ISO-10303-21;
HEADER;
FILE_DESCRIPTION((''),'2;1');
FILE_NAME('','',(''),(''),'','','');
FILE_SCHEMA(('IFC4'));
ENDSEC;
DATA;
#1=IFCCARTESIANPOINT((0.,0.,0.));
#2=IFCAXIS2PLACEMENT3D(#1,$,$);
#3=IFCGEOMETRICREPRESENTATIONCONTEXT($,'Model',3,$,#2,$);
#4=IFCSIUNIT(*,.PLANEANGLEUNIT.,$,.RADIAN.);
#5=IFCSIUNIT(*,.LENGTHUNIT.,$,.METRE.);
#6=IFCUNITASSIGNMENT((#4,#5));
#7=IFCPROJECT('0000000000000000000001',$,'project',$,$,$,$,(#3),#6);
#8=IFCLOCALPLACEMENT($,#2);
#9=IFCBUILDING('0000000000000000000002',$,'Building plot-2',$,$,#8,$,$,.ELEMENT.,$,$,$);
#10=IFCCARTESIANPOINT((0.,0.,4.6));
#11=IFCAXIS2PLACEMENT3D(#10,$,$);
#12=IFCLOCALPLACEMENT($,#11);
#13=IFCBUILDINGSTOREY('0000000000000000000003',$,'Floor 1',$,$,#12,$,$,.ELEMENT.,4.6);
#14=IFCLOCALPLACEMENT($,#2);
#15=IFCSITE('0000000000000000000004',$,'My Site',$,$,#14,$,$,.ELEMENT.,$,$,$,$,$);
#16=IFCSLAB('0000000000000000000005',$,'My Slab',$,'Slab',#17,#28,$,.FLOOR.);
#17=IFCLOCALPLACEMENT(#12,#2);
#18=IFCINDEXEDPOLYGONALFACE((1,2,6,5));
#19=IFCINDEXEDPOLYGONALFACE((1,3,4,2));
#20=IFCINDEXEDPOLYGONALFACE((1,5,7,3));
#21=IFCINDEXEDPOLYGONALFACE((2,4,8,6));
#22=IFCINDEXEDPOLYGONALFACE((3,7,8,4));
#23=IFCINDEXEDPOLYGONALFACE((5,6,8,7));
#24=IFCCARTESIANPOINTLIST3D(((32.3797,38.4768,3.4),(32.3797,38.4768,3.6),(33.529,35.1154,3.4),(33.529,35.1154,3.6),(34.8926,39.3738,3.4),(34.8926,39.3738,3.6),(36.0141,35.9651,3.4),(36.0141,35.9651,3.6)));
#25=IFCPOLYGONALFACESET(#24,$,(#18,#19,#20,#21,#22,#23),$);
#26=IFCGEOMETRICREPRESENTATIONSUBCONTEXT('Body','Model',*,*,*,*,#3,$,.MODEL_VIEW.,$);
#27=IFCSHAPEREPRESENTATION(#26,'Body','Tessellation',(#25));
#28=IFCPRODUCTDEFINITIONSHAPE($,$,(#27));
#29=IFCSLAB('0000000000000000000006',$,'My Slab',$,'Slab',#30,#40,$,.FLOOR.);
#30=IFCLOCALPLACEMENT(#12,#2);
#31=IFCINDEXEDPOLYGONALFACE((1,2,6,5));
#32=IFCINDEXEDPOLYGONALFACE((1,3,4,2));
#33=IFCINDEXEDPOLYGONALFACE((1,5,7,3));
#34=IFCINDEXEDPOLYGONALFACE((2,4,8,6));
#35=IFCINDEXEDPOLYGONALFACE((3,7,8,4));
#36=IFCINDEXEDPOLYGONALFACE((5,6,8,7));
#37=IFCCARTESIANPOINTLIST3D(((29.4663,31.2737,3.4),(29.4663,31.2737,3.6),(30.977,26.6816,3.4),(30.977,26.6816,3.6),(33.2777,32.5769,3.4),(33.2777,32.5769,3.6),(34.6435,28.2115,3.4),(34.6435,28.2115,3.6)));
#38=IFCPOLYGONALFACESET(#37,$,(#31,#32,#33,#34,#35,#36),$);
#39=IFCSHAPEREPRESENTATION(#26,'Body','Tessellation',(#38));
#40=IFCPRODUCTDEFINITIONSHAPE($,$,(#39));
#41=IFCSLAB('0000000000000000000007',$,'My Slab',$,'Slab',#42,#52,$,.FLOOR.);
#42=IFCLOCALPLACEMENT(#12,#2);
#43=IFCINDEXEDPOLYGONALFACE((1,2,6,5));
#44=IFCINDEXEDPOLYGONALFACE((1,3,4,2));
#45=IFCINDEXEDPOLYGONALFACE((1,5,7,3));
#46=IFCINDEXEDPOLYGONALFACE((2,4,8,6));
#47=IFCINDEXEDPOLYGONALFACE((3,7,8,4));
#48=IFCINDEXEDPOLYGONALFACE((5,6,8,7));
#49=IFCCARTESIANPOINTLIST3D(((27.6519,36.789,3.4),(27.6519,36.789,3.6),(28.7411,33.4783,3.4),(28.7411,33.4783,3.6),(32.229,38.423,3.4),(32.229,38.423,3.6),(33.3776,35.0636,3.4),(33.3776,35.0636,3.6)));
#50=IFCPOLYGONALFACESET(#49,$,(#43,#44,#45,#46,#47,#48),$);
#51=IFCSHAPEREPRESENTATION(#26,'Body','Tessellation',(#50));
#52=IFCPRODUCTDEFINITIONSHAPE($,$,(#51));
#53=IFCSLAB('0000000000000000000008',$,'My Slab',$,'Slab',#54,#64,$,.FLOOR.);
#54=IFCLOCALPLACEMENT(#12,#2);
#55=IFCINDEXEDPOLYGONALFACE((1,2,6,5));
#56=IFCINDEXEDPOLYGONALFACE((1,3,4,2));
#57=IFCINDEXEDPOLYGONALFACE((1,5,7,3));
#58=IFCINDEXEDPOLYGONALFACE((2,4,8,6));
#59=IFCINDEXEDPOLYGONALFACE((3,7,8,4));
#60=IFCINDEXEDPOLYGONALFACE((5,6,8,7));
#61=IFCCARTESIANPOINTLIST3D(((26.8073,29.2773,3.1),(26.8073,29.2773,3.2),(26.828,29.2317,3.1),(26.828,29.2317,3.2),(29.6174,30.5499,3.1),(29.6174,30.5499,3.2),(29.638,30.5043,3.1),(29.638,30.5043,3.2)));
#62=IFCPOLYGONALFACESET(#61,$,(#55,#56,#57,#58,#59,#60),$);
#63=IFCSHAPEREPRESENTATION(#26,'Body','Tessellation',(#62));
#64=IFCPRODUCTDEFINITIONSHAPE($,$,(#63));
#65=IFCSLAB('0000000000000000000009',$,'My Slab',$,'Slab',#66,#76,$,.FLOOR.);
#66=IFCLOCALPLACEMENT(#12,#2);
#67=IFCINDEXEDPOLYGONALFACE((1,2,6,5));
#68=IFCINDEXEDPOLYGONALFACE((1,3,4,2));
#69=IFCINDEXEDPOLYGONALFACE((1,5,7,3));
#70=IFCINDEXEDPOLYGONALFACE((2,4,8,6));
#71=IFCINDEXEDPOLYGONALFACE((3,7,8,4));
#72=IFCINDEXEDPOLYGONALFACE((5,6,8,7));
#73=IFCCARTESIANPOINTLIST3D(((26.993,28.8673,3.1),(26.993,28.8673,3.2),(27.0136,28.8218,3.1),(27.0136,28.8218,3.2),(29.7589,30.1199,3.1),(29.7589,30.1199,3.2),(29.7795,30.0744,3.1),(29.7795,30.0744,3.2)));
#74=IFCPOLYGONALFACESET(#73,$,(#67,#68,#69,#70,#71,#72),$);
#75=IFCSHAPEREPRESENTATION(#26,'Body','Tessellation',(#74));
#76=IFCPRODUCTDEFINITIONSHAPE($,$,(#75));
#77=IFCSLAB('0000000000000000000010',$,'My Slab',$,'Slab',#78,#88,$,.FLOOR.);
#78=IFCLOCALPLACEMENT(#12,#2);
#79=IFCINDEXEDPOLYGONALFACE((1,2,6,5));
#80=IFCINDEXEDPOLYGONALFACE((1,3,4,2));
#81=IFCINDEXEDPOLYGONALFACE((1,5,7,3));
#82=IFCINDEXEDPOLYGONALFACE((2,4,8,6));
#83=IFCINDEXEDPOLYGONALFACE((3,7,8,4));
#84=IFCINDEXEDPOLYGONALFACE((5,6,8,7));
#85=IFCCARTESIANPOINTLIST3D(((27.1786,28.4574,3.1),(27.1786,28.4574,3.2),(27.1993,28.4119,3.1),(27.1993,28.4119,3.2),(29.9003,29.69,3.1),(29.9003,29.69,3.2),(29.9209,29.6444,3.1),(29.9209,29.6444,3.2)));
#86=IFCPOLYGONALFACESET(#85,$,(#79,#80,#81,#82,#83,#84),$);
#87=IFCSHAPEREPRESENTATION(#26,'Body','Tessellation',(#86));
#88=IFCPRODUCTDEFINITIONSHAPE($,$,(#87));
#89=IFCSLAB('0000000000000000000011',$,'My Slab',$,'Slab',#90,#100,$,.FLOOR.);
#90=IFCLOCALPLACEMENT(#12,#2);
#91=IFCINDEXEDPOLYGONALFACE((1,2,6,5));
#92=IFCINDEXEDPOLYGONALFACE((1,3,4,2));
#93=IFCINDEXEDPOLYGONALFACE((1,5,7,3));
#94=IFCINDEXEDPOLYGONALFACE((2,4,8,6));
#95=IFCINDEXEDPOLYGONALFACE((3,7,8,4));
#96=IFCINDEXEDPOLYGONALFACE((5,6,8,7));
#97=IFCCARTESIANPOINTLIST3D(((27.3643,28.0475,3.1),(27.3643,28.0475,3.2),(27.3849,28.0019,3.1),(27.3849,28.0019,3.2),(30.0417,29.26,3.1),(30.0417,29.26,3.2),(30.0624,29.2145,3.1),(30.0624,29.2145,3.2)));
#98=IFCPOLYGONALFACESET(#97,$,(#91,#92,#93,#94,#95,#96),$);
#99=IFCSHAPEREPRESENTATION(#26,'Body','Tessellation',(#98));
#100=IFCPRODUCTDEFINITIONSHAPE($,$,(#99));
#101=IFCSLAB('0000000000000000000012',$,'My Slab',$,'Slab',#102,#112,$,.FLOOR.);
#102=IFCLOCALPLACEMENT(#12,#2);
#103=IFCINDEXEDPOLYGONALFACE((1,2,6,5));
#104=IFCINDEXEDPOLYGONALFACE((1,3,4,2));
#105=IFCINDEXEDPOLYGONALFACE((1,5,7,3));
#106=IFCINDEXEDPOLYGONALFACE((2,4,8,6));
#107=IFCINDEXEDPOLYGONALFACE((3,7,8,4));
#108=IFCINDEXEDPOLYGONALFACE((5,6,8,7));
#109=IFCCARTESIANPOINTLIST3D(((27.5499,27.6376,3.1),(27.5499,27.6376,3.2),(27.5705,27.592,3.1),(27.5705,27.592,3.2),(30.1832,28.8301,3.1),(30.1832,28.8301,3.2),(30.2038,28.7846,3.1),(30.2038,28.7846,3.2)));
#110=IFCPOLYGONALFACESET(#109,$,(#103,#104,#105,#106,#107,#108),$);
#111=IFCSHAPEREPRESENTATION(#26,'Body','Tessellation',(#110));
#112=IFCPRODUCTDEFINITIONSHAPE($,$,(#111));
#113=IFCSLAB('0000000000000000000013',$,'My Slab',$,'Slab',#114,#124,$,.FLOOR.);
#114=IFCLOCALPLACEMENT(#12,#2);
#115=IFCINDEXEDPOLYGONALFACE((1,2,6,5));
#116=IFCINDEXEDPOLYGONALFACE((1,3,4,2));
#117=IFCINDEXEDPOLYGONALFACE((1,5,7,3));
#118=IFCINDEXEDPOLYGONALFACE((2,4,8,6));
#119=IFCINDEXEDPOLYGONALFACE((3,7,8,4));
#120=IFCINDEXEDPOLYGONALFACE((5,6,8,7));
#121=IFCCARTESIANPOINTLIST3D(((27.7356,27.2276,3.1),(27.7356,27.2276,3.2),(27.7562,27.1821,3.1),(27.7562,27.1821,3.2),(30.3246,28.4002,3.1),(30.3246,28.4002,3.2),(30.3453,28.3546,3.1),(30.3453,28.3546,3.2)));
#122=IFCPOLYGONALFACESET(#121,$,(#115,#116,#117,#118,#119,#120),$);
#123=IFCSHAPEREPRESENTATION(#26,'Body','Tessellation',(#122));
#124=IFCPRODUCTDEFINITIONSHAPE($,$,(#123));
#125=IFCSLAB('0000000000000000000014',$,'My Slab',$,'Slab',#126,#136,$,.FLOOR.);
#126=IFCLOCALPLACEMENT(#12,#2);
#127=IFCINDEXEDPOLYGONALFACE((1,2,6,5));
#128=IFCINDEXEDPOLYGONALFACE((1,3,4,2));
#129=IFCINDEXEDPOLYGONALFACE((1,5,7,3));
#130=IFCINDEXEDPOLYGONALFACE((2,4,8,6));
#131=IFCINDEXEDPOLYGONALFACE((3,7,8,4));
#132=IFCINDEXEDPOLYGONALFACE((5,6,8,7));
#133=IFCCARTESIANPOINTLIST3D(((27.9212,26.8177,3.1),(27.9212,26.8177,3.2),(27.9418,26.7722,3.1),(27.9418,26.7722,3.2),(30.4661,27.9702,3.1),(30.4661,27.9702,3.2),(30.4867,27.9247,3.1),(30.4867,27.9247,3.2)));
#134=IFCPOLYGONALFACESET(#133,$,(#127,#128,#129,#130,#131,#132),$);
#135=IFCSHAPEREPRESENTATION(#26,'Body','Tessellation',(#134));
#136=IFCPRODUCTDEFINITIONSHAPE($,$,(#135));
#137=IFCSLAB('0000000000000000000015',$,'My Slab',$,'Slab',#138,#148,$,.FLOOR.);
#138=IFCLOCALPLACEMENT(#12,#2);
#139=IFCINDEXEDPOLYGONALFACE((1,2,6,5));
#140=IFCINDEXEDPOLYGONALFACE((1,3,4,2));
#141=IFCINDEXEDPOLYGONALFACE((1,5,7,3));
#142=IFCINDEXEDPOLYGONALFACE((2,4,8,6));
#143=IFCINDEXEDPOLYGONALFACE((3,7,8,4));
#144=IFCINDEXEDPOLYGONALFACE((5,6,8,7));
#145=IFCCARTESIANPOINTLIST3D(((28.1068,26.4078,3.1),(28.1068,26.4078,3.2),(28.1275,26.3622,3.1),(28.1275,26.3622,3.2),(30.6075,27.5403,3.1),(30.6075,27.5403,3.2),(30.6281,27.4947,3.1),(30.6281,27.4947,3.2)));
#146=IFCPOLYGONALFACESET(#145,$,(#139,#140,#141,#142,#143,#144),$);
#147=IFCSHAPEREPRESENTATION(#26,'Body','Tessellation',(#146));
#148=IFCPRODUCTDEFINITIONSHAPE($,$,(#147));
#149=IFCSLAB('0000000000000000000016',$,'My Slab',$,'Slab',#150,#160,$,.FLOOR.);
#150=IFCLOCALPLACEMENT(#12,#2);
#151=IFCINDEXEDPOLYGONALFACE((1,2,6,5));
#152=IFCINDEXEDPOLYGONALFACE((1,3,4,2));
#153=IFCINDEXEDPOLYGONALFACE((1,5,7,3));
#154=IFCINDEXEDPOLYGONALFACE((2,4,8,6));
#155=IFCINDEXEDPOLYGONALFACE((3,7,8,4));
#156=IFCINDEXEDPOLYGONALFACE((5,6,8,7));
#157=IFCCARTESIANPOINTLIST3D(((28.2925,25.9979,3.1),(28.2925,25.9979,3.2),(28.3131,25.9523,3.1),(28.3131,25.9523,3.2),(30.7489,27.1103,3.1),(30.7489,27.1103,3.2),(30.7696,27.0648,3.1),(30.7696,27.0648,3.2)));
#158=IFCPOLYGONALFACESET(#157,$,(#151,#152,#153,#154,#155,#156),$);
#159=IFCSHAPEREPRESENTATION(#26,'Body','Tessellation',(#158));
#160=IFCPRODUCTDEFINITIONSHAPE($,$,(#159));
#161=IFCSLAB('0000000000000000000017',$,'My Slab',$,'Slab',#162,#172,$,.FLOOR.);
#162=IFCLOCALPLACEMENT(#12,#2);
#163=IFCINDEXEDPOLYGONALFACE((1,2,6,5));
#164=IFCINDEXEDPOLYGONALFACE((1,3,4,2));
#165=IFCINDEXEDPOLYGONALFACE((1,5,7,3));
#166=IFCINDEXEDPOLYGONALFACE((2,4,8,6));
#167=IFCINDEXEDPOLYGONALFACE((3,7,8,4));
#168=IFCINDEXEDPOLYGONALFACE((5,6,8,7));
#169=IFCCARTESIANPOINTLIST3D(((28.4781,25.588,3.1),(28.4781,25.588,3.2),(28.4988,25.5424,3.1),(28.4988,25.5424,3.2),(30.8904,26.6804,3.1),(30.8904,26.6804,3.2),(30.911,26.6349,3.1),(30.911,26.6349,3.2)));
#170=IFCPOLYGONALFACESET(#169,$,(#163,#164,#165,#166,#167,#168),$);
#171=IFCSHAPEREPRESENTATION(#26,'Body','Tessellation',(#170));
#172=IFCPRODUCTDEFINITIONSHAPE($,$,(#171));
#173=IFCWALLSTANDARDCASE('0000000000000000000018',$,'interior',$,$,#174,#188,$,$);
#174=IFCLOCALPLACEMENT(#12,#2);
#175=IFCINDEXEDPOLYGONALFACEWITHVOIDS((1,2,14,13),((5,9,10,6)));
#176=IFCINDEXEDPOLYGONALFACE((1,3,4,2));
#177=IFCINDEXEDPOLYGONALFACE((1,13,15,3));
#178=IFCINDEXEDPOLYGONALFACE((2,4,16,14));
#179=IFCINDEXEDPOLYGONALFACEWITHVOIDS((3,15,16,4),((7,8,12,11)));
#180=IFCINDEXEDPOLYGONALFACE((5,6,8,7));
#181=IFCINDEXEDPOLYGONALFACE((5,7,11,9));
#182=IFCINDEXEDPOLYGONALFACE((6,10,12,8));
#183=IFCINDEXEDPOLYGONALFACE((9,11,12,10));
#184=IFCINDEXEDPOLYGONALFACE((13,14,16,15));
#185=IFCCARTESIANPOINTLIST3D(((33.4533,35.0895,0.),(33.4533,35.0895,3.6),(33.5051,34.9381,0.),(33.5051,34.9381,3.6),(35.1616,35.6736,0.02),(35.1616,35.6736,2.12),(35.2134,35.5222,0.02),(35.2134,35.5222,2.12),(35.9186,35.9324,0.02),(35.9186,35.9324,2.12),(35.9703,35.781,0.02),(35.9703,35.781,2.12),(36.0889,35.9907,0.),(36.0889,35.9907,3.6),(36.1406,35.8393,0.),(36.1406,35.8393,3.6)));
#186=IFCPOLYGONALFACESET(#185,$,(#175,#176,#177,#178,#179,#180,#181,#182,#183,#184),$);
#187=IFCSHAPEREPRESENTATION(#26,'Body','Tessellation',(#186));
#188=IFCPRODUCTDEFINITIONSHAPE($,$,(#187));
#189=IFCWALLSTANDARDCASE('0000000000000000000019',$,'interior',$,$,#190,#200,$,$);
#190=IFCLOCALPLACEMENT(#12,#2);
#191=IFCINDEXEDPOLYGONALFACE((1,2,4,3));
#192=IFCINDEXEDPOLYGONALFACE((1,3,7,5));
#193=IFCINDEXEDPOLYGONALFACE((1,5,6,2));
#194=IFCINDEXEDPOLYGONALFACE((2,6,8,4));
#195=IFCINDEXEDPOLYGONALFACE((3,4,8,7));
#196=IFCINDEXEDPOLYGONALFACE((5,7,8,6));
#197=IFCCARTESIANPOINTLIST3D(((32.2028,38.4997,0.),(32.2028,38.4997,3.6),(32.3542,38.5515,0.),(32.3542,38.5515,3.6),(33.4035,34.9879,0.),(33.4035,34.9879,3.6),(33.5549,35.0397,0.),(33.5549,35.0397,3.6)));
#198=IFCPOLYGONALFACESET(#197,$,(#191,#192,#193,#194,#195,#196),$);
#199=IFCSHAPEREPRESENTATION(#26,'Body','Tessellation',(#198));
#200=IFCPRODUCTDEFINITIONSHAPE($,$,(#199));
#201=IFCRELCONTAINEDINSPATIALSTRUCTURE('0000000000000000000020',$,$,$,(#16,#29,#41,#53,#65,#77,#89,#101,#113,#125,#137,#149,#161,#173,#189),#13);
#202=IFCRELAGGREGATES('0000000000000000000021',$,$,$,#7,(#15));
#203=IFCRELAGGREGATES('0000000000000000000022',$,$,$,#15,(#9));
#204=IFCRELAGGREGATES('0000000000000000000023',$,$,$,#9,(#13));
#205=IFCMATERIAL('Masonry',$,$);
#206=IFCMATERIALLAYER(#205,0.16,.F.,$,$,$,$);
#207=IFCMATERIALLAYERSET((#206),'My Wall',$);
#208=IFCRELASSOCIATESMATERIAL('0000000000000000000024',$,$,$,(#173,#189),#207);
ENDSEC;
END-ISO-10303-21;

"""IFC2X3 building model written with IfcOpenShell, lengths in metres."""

from ifc_helpers import new_model, si_unit, frame, origin, place, context, subcontext, project, spatial, polyline, outline, extrude, material, layer, layer_set, layer_usage, element, save


model = new_model("IFC2X3")

# Units and contexts
model_context = context("Model", 3, world=origin())
body_context = subcontext(model_context, "Body", "Model", "MODEL_VIEW")
ifc_project = project(units=[si_unit("PLANEANGLEUNIT", "RADIAN"), si_unit("LENGTHUNIT", "METRE")], contexts=[model_context])

# Site, building, storey
site_placement = place(None, origin())
site = spatial("IfcSite", under=ifc_project, at=site_placement, Name="My Site", CompositionType="ELEMENT")
building_placement = place(None, origin())
building = spatial("IfcBuilding", under=site, at=building_placement, Name="Building plot-2", CompositionType="ELEMENT")
storey_placement = place(None, frame((0.0, 0.0, 4.6)))
storey = spatial("IfcBuildingStorey", under=building, at=storey_placement, Name="Floor 1", CompositionType="ELEMENT", Elevation=4.6)

# Slabs
slab_1_placement = place(storey_placement, frame((0.0, 0.0, 3.4)))
element("IfcSlab", 1, at=slab_1_placement, inside=storey, Name="My Slab", ObjectType="Slab", PredefinedType="FLOOR", context=body_context, shape_type="SweptSolid", body=[
    extrude(outline(polyline([(33.529, 35.1154), (36.0141, 35.9651), (34.8926, 39.3738), (32.3797, 38.4768), (33.529, 35.1154)])), origin(), (0.0, 0.0, 1.0), 0.2),
])
slab_2_placement = place(storey_placement, frame((0.0, 0.0, 3.4)))
element("IfcSlab", 2, at=slab_2_placement, inside=storey, Name="My Slab", ObjectType="Slab", PredefinedType="FLOOR", context=body_context, shape_type="SweptSolid", body=[
    extrude(outline(polyline([(30.977, 26.6816), (34.6435, 28.2115), (33.2777, 32.5769), (29.4663, 31.2737), (30.977, 26.6816)])), origin(), (0.0, 0.0, 1.0), 0.2),
])
slab_3_placement = place(storey_placement, frame((0.0, 0.0, 3.4)))
element("IfcSlab", 3, at=slab_3_placement, inside=storey, Name="My Slab", ObjectType="Slab", PredefinedType="FLOOR", context=body_context, shape_type="SweptSolid", body=[
    extrude(outline(polyline([(28.7411, 33.4783), (33.3776, 35.0636), (32.229, 38.423), (27.6519, 36.789), (28.7411, 33.4783)])), origin(), (0.0, 0.0, 1.0), 0.2),
])
slab_4_placement = place(storey_placement, frame((0.0, 0.0, 3.1)))
element("IfcSlab", 4, at=slab_4_placement, inside=storey, Name="My Slab", ObjectType="Slab", PredefinedType="FLOOR", context=body_context, shape_type="SweptSolid", body=[
    extrude(outline(polyline([(26.8073, 29.2773), (26.828, 29.2317), (29.638, 30.5043), (29.6174, 30.5499), (26.8073, 29.2773)])), origin(), (0.0, 0.0, 1.0), 0.1),
])
slab_5_placement = place(storey_placement, frame((0.0, 0.0, 3.1)))
element("IfcSlab", 5, at=slab_5_placement, inside=storey, Name="My Slab", ObjectType="Slab", PredefinedType="FLOOR", context=body_context, shape_type="SweptSolid", body=[
    extrude(outline(polyline([(26.993, 28.8673), (27.0136, 28.8218), (29.7795, 30.0744), (29.7589, 30.1199), (26.993, 28.8673)])), origin(), (0.0, 0.0, 1.0), 0.1),
])
slab_6_placement = place(storey_placement, frame((0.0, 0.0, 3.1)))
element("IfcSlab", 6, at=slab_6_placement, inside=storey, Name="My Slab", ObjectType="Slab", PredefinedType="FLOOR", context=body_context, shape_type="SweptSolid", body=[
    extrude(outline(polyline([(27.1786, 28.4574), (27.1993, 28.4119), (29.9209, 29.6444), (29.9003, 29.69), (27.1786, 28.4574)])), origin(), (0.0, 0.0, 1.0), 0.1),
])
slab_7_placement = place(storey_placement, frame((0.0, 0.0, 3.1)))
element("IfcSlab", 7, at=slab_7_placement, inside=storey, Name="My Slab", ObjectType="Slab", PredefinedType="FLOOR", context=body_context, shape_type="SweptSolid", body=[
    extrude(outline(polyline([(27.3643, 28.0475), (27.3849, 28.0019), (30.0624, 29.2145), (30.0417, 29.26), (27.3643, 28.0475)])), origin(), (0.0, 0.0, 1.0), 0.1),
])
slab_8_placement = place(storey_placement, frame((0.0, 0.0, 3.1)))
element("IfcSlab", 8, at=slab_8_placement, inside=storey, Name="My Slab", ObjectType="Slab", PredefinedType="FLOOR", context=body_context, shape_type="SweptSolid", body=[
    extrude(outline(polyline([(27.5499, 27.6376), (27.5705, 27.592), (30.2038, 28.7846), (30.1832, 28.8301), (27.5499, 27.6376)])), origin(), (0.0, 0.0, 1.0), 0.1),
])
slab_9_placement = place(storey_placement, frame((0.0, 0.0, 3.1)))
element("IfcSlab", 9, at=slab_9_placement, inside=storey, Name="My Slab", ObjectType="Slab", PredefinedType="FLOOR", context=body_context, shape_type="SweptSolid", body=[
    extrude(outline(polyline([(27.7356, 27.2276), (27.7562, 27.1821), (30.3453, 28.3546), (30.3246, 28.4002), (27.7356, 27.2276)])), origin(), (0.0, 0.0, 1.0), 0.1),
])
slab_10_placement = place(storey_placement, frame((0.0, 0.0, 3.1)))
element("IfcSlab", 10, at=slab_10_placement, inside=storey, Name="My Slab", ObjectType="Slab", PredefinedType="FLOOR", context=body_context, shape_type="SweptSolid", body=[
    extrude(outline(polyline([(27.9212, 26.8177), (27.9418, 26.7722), (30.4867, 27.9247), (30.4661, 27.9702), (27.9212, 26.8177)])), origin(), (0.0, 0.0, 1.0), 0.1),
])
slab_11_placement = place(storey_placement, frame((0.0, 0.0, 3.1)))
element("IfcSlab", 11, at=slab_11_placement, inside=storey, Name="My Slab", ObjectType="Slab", PredefinedType="FLOOR", context=body_context, shape_type="SweptSolid", body=[
    extrude(outline(polyline([(28.1068, 26.4078), (28.1275, 26.3622), (30.6281, 27.4947), (30.6075, 27.5403), (28.1068, 26.4078)])), origin(), (0.0, 0.0, 1.0), 0.1),
])
slab_12_placement = place(storey_placement, frame((0.0, 0.0, 3.1)))
element("IfcSlab", 12, at=slab_12_placement, inside=storey, Name="My Slab", ObjectType="Slab", PredefinedType="FLOOR", context=body_context, shape_type="SweptSolid", body=[
    extrude(outline(polyline([(28.2925, 25.9979), (28.3131, 25.9523), (30.7696, 27.0648), (30.7489, 27.1103), (28.2925, 25.9979)])), origin(), (0.0, 0.0, 1.0), 0.1),
])
slab_13_placement = place(storey_placement, frame((0.0, 0.0, 3.1)))
element("IfcSlab", 13, at=slab_13_placement, inside=storey, Name="My Slab", ObjectType="Slab", PredefinedType="FLOOR", context=body_context, shape_type="SweptSolid", body=[
    extrude(outline(polyline([(28.4781, 25.588), (28.4988, 25.5424), (30.911, 26.6349), (30.8904, 26.6804), (28.4781, 25.588)])), origin(), (0.0, 0.0, 1.0), 0.1),
])

# Wall, opening
ifc_material = material(Name="Masonry")
ifc_layer = layer(ifc_material, 0.16, ventilated=False)
ifc_layer_set = layer_set([ifc_layer], Name="My Wall")
ifc_layer_usage = layer_usage(ifc_layer_set, "AXIS2", "NEGATIVE", 0.08)
wall_1_placement = place(storey_placement, origin())
wall_1 = element("IfcWallStandardCase", 14, at=wall_1_placement, inside=storey, material=ifc_layer_usage, Name="interior", context=body_context, shape_type="SweptSolid", body=[
    extrude(outline(polyline([(33.4533, 35.0895), (33.5051, 34.9381), (36.1406, 35.8393), (36.0889, 35.9907), (33.4533, 35.0895)])), origin(), (0.0, 0.0, 1.0), 3.6),
])
opening_1_placement = place(storey_placement, frame((0.0, 0.0, 0.02)))
element("IfcOpeningElement", 15, at=opening_1_placement, cuts=wall_1, ObjectType="Opening", context=body_context, shape_type="SweptSolid", body=[
    extrude(outline(polyline([(35.2134, 35.5222), (35.9703, 35.781), (35.9186, 35.9324), (35.1616, 35.6736), (35.2134, 35.5222)])), origin(), (0.0, 0.0, 1.0), 2.1),
])

# Wall
wall_2_placement = place(storey_placement, origin())
element("IfcWallStandardCase", 16, at=wall_2_placement, inside=storey, material=ifc_layer_usage, Name="interior", context=body_context, shape_type="SweptSolid", body=[
    extrude(outline(polyline([(33.4035, 34.9879), (33.5549, 35.0397), (32.3542, 38.5515), (32.2028, 38.4997), (33.4035, 34.9879)])), origin(), (0.0, 0.0, 1.0), 3.6),
])

save(model, "model.ifc")
